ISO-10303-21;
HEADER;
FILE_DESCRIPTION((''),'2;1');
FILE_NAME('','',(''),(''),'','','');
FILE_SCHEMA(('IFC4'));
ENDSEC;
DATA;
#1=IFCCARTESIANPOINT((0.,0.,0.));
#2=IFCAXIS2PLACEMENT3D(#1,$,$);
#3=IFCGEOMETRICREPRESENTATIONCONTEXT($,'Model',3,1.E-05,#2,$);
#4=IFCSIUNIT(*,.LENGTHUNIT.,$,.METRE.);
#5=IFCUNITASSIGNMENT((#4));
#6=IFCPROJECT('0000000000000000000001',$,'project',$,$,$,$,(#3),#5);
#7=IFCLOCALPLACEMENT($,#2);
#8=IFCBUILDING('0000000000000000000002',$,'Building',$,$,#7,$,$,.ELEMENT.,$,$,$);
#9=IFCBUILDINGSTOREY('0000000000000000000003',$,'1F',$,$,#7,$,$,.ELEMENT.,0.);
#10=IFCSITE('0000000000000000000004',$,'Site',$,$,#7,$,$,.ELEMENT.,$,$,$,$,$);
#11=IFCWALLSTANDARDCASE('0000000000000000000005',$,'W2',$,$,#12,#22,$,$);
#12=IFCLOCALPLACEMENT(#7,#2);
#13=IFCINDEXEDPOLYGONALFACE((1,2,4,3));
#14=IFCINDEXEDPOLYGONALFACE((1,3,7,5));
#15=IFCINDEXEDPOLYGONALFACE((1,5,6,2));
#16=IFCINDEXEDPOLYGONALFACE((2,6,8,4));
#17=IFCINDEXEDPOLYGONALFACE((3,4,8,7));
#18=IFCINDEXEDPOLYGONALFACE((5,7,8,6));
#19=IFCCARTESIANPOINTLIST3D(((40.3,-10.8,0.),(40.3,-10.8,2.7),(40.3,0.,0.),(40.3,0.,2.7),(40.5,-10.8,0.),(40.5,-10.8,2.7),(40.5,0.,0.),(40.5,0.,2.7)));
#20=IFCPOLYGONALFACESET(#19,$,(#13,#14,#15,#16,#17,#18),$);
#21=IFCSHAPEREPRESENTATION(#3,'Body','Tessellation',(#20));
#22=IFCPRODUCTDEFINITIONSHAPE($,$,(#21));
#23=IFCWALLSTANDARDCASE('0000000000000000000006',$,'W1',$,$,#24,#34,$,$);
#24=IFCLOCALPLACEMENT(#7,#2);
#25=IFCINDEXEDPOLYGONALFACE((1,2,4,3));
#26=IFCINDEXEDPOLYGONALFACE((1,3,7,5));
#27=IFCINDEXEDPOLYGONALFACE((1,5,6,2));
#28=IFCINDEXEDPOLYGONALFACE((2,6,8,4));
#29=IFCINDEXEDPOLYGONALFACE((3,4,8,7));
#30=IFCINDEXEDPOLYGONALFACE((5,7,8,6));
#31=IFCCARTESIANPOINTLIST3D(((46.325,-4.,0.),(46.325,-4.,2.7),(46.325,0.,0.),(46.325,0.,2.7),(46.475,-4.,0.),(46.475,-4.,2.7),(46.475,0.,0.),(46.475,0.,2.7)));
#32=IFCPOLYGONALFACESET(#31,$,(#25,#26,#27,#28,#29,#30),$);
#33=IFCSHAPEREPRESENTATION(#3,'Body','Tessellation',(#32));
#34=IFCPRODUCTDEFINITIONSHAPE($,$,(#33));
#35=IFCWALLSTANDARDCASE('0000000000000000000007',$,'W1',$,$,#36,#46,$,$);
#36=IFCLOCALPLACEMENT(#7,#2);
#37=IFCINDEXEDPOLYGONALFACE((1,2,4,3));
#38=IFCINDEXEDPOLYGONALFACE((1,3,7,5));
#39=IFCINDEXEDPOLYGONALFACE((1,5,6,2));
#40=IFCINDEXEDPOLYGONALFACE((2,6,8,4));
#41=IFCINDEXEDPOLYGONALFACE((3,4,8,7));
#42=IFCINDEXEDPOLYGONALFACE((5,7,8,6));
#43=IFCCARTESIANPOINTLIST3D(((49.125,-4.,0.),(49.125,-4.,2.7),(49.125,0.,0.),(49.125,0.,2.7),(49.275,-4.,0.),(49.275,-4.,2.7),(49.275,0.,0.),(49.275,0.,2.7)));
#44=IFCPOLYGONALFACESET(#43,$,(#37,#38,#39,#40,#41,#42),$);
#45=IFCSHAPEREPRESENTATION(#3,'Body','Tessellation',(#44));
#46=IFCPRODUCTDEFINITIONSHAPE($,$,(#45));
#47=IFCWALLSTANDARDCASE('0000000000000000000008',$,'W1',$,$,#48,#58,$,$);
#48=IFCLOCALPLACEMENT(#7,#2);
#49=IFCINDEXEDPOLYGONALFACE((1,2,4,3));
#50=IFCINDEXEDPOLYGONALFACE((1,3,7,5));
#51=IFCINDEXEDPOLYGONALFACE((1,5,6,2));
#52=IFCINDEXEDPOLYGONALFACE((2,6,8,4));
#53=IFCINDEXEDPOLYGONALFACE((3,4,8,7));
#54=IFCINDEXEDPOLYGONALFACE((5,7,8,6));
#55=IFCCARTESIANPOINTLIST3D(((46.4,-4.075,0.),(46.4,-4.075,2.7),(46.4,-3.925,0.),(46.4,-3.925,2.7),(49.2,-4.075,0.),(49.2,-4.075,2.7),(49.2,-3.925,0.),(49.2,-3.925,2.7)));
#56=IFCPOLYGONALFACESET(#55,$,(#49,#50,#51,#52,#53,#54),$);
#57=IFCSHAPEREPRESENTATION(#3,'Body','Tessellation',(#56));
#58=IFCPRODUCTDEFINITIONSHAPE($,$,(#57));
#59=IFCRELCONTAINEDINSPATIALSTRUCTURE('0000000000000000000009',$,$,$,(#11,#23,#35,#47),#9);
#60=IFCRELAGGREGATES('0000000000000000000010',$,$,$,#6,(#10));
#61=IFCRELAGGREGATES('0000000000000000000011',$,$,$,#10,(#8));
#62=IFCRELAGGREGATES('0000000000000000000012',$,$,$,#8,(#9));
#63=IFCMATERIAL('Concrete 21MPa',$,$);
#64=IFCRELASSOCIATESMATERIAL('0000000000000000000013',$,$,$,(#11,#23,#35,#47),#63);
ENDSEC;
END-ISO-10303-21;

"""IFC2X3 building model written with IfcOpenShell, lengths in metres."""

from ifc_helpers import new_model, si_unit, frame, origin, origin_2d, place, context, project, spatial, rectangle, extrude, material, element, save


model = new_model("IFC2X3")

# Units and contexts
model_context = context("Model", 3, precision=1e-05, world=origin())
ifc_project = project(units=[si_unit("LENGTHUNIT", "METRE")], contexts=[model_context])

# Site, building, storey
placement = place(None, origin())
site = spatial("IfcSite", under=ifc_project, at=placement, Name="Site", CompositionType="ELEMENT")
building = spatial("IfcBuilding", under=site, at=placement, Name="Building", CompositionType="ELEMENT")
storey = spatial("IfcBuildingStorey", under=building, at=placement, Name="1F", CompositionType="ELEMENT", Elevation=0.0)

# Shared definitions
ifc_material = material(Name="Concrete 21MPa")

# Walls
wall_1_placement = place(None, frame((40.4, -5.4, 0.0)))
element("IfcWallStandardCase", 1, at=wall_1_placement, inside=storey, material=ifc_material, Name="W2", context=model_context, shape_type="SweptSolid", body=[
    extrude(rectangle(XDim=0.2, YDim=10.8, at=origin_2d()), origin(), (0.0, 0.0, 1.0), 2.7),
])
for number, where, name in (
    (2, (46.4, -2.0, 0.0), "W1"),
    (3, (49.2, -2.0, 0.0), "W1"),
):
    element("IfcWallStandardCase", number, at=place(None, frame(where)), inside=storey, material=ifc_material, Name=name, context=model_context, shape_type="SweptSolid", body=[
        extrude(rectangle(XDim=0.15, YDim=4.0, at=origin_2d()), origin(), (0.0, 0.0, 1.0), 2.7),
    ])
wall_2_placement = place(None, frame((47.8, -4.0, 0.0)))
element("IfcWallStandardCase", 4, at=wall_2_placement, inside=storey, material=ifc_material, Name="W1", context=model_context, shape_type="SweptSolid", body=[
    extrude(rectangle(XDim=2.8, YDim=0.15, at=origin_2d()), origin(), (0.0, 0.0, 1.0), 2.7),
])

save(model, "model.ifc")
